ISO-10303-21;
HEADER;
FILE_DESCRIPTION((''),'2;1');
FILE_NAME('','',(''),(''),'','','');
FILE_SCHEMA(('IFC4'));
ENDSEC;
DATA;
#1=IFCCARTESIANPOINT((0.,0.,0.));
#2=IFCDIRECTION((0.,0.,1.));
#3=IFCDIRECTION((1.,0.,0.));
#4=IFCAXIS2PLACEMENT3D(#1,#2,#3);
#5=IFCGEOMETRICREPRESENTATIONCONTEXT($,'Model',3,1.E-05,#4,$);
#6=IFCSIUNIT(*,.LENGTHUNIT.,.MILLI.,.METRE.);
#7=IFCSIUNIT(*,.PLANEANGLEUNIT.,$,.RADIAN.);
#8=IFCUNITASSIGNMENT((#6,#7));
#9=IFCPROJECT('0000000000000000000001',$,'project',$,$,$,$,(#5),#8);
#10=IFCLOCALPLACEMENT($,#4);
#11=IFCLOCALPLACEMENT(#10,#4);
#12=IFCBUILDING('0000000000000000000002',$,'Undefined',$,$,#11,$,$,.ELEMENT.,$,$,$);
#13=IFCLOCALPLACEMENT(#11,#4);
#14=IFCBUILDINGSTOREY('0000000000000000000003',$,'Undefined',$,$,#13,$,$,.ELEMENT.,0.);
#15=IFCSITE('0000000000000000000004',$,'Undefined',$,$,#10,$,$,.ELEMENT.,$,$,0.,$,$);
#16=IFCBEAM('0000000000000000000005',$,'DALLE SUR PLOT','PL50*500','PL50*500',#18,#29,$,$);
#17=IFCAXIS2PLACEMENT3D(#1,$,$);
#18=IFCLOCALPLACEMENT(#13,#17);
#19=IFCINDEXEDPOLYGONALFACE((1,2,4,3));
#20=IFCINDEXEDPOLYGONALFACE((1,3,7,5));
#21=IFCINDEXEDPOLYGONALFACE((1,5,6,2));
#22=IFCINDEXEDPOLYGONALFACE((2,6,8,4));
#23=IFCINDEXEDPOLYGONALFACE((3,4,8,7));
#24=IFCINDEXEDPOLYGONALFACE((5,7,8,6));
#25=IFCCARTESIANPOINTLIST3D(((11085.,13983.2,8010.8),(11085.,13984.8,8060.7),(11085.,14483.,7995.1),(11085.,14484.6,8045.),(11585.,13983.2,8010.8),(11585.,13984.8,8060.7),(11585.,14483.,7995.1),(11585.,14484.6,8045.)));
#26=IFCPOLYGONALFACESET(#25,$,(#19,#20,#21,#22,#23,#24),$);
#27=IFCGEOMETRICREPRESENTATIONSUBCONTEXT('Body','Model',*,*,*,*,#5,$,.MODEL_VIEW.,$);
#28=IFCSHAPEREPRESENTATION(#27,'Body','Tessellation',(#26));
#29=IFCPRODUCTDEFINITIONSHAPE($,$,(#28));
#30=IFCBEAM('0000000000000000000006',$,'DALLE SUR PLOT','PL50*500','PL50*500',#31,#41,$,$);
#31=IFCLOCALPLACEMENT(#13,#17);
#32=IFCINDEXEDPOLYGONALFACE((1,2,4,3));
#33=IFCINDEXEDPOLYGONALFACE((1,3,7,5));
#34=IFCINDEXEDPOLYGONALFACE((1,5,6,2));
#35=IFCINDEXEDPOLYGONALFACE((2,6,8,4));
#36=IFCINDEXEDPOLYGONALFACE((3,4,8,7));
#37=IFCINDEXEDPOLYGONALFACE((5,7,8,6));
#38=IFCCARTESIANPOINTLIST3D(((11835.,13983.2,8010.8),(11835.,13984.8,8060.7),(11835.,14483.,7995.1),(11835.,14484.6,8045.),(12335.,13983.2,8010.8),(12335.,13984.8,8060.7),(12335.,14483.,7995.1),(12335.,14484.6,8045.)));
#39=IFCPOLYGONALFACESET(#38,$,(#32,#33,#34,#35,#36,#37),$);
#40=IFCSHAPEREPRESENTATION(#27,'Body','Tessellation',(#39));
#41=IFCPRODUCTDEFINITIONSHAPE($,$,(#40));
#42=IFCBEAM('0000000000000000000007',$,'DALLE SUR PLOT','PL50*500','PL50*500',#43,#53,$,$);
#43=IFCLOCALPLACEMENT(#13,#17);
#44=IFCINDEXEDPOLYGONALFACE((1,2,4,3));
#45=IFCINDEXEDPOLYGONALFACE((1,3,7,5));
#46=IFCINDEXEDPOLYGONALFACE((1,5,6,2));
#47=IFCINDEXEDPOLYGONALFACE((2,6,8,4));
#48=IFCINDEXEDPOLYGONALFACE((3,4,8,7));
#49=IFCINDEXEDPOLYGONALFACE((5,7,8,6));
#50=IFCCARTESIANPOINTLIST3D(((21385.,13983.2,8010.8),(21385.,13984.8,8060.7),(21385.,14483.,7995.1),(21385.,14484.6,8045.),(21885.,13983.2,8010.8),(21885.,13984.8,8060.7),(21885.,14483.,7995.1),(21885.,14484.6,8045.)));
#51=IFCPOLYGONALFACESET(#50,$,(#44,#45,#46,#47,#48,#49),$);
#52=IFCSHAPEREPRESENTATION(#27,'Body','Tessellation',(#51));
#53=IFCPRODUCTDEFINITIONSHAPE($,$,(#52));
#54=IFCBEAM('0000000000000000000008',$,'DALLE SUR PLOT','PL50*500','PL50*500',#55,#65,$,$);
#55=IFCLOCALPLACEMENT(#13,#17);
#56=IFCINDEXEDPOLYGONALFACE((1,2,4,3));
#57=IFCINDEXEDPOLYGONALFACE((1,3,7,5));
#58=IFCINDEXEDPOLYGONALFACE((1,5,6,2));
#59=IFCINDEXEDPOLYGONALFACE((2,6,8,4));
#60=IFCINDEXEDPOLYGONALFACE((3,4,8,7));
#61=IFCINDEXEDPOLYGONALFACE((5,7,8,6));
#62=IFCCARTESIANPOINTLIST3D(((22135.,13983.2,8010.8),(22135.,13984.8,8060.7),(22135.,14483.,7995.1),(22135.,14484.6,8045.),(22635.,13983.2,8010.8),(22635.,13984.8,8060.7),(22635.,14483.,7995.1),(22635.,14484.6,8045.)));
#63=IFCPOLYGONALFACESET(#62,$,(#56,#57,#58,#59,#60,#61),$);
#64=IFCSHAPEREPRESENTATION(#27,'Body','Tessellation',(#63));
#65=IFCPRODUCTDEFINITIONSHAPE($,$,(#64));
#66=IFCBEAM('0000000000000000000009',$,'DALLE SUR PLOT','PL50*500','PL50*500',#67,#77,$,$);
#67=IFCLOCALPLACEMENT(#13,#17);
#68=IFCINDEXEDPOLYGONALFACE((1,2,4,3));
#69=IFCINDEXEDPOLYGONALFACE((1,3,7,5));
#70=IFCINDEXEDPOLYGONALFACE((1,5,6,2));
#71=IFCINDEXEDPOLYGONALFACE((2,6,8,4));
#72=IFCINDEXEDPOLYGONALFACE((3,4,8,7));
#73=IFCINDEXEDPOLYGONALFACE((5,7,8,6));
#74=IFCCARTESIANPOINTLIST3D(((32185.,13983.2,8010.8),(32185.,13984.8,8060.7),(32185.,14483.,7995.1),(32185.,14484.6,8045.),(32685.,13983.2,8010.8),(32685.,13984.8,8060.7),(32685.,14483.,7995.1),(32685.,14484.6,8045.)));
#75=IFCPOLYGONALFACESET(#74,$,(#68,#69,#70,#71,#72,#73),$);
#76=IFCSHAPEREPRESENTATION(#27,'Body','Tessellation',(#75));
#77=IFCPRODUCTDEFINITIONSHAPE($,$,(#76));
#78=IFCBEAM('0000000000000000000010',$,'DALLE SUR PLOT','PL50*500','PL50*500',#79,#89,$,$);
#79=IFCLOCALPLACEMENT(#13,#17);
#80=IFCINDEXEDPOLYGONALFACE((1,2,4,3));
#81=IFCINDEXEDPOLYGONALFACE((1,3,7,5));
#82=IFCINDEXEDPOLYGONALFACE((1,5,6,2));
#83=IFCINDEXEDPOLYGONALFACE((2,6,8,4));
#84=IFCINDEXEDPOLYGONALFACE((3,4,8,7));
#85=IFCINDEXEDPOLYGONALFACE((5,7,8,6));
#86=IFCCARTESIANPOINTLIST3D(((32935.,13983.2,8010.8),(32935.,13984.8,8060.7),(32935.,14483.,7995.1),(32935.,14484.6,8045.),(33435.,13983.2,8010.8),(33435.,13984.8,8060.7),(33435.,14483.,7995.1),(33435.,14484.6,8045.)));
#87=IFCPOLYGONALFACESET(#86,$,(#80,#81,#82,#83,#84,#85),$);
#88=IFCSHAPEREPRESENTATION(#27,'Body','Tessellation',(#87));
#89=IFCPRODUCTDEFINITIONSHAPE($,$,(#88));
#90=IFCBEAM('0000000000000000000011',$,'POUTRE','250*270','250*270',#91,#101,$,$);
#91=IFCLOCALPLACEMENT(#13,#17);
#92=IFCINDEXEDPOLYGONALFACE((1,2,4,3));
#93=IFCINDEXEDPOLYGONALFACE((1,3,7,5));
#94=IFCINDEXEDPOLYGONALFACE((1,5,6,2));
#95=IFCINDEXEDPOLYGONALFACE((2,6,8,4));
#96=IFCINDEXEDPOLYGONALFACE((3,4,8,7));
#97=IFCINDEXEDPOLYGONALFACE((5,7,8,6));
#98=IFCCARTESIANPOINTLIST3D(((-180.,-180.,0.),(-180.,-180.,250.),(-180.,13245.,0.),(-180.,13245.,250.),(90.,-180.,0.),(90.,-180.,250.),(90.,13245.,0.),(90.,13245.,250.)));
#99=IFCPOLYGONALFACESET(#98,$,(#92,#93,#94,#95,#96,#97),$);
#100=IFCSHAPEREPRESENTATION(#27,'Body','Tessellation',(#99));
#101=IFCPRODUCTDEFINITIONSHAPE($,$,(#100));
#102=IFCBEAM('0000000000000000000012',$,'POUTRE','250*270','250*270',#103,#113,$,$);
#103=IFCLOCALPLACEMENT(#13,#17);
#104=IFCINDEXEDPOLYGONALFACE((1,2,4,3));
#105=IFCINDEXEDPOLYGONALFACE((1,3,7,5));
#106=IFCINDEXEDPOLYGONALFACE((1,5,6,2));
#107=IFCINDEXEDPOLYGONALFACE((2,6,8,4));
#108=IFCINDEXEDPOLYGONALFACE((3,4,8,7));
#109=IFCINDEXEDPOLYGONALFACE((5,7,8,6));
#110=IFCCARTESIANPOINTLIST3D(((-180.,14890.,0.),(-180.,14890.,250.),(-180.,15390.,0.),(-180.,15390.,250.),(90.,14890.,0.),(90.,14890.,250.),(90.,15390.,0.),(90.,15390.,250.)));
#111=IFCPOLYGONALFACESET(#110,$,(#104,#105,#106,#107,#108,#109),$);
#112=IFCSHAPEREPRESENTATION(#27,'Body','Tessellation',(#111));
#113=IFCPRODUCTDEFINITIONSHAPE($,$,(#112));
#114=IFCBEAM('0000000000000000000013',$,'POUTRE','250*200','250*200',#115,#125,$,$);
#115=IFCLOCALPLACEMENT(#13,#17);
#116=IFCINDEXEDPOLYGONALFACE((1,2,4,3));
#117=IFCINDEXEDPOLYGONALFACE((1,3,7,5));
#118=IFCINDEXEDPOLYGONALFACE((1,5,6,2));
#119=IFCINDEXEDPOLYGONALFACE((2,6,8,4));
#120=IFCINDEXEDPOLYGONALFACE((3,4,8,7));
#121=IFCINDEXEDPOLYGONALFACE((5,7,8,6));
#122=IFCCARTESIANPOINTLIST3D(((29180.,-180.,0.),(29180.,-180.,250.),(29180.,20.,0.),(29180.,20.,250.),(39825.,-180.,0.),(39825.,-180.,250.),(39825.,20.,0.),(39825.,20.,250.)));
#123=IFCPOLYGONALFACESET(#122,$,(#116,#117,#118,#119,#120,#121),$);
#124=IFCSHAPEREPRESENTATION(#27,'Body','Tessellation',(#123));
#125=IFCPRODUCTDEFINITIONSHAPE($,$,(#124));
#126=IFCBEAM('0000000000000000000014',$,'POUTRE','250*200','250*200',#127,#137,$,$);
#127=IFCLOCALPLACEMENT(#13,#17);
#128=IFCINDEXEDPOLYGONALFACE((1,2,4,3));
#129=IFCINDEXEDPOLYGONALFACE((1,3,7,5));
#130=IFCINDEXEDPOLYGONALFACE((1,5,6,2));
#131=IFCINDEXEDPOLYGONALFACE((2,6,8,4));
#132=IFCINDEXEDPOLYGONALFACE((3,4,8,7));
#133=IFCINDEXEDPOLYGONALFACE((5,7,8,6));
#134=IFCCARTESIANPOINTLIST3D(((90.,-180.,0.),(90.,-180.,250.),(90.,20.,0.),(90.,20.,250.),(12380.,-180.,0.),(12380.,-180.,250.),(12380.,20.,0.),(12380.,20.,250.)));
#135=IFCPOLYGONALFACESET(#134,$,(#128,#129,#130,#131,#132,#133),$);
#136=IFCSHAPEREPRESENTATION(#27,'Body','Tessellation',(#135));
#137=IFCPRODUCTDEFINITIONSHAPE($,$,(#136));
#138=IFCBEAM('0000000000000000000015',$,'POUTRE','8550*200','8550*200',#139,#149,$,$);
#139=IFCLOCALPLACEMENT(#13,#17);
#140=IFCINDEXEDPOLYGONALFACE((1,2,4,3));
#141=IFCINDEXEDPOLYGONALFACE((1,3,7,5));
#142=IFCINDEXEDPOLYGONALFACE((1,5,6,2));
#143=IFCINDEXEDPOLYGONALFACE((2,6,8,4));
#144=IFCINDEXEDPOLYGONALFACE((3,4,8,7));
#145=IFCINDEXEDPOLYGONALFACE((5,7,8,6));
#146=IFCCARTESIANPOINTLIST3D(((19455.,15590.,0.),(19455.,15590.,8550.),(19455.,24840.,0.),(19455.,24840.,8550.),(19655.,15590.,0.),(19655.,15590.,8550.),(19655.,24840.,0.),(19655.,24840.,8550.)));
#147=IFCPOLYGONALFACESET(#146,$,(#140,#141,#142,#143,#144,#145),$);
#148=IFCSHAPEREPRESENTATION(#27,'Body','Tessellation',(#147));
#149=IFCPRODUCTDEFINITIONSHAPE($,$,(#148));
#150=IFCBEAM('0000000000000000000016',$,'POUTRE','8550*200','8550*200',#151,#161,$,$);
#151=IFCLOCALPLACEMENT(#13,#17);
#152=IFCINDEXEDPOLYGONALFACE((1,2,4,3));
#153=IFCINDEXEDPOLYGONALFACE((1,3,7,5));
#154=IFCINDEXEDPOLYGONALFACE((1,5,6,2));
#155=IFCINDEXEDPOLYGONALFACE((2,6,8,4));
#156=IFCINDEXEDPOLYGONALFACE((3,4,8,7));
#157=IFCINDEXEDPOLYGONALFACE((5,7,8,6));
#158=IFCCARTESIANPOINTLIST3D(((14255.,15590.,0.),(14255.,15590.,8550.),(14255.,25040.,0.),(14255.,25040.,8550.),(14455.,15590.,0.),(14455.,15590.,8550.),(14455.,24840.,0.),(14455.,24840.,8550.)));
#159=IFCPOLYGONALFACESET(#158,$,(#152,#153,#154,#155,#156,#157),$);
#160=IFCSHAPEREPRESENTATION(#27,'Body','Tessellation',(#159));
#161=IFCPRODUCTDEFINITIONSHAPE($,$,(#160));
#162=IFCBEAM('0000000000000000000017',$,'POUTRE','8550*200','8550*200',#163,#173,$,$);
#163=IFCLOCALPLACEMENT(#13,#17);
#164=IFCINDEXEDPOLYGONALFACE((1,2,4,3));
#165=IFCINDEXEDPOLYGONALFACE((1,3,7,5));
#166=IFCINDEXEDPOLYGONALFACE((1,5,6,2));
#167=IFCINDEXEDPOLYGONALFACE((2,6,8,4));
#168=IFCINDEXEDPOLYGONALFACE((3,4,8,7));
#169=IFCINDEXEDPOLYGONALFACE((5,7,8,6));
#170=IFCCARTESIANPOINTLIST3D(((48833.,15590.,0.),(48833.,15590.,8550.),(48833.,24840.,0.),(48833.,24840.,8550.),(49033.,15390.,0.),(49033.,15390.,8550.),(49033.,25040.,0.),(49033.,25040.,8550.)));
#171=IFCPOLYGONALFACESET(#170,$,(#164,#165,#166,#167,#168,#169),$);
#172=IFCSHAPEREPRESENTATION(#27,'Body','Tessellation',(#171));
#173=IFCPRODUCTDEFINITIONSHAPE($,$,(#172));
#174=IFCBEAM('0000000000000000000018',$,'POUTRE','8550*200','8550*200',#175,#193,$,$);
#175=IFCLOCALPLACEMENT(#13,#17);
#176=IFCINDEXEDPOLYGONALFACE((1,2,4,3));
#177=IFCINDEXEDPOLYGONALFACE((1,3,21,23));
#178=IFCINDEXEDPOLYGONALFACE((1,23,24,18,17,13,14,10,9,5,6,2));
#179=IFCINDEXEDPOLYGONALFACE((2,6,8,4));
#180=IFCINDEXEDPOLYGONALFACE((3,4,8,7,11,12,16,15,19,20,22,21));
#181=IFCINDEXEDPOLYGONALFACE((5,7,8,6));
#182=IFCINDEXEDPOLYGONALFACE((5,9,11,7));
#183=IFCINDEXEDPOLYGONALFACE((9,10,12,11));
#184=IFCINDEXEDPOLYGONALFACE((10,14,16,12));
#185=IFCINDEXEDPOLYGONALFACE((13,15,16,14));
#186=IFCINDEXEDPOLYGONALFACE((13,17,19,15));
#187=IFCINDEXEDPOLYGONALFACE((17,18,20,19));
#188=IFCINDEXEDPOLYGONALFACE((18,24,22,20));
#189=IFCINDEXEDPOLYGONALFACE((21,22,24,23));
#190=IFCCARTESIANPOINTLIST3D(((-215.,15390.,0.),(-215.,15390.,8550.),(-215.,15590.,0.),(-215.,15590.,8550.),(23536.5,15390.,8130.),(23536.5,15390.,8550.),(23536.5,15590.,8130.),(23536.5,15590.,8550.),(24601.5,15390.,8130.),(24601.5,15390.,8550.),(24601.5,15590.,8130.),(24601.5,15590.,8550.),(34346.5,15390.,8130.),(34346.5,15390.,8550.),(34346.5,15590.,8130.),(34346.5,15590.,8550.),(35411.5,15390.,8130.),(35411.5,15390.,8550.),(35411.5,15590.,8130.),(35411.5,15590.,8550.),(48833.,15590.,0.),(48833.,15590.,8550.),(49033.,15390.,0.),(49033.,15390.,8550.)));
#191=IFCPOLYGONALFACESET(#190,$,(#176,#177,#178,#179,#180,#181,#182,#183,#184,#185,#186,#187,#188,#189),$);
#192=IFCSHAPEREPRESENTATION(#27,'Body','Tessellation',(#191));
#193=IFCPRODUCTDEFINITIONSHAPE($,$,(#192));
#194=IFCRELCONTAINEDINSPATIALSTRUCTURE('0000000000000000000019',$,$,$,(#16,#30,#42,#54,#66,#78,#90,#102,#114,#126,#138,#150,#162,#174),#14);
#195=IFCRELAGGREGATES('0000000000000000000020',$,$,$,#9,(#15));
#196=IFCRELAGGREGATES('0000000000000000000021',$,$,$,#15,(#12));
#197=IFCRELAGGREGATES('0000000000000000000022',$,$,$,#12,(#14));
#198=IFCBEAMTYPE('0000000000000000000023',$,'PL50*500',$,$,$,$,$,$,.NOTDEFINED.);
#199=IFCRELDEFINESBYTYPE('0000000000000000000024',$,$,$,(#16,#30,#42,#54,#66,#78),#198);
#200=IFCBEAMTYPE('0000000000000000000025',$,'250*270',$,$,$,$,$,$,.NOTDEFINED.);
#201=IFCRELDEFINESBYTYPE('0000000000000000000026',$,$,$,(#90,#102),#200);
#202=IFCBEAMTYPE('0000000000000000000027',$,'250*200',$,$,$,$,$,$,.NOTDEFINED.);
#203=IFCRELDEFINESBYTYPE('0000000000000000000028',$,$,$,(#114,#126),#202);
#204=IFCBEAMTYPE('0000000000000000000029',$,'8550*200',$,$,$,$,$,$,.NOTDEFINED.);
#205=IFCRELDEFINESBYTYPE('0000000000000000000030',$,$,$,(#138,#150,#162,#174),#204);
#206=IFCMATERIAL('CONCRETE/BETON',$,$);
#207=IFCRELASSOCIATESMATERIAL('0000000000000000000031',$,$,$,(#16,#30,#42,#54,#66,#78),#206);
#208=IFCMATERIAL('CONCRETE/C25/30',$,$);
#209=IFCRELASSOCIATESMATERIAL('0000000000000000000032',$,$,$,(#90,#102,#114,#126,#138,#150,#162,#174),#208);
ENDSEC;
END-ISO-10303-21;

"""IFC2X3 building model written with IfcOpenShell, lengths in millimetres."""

from ifc_helpers import new_model, si_unit, frame, origin_with_axes, origin_2d_with_axis, place, context, subcontext, project, spatial, polyline, rectangle, outline, extrude, boolean, clip, halfspace, material, type_object, element, save


model = new_model("IFC2X3")

# Units and contexts
model_context = context("Model", 3, precision=1e-05, world=origin_with_axes())
body_context = subcontext(model_context, "Body", "Model", "MODEL_VIEW")
ifc_project = project(units=[si_unit("LENGTHUNIT", "METRE", prefix="MILLI"), si_unit("PLANEANGLEUNIT", "RADIAN")], contexts=[model_context])

# Site, building, storey
site_placement = place(None, origin_with_axes())
site = spatial("IfcSite", under=ifc_project, at=site_placement, Name="Undefined", CompositionType="ELEMENT", RefElevation=0.0)
building_placement = place(site_placement, origin_with_axes())
building = spatial("IfcBuilding", under=site, at=building_placement, Name="Undefined", CompositionType="ELEMENT")
storey_placement = place(building_placement, origin_with_axes())
storey = spatial("IfcBuildingStorey", under=building, at=storey_placement, Name="Undefined", CompositionType="ELEMENT", Elevation=0.0)

# Beams
ifc_material_1 = material(Name="CONCRETE/BETON")
beam_type_1 = type_object("IfcBeamType", Name="PL50*500", PredefinedType="NOTDEFINED")
for number, where, z_axis, x_axis, name in (
    (1, (11335.0, 14483.8, 8020.0), (-1.0, 0.0, 0.0), (0.0, -0.999507, 0.031411), "DALLE SUR PLOT"),
    (2, (12085.0, 14483.8, 8020.0), (-1.0, 0.0, 0.0), (0.0, -0.999507, 0.031411), "DALLE SUR PLOT"),
    (3, (21635.0, 14483.8, 8020.0), (-1.0, 0.0, 0.0), (0.0, -0.999507, 0.031411), "DALLE SUR PLOT"),
    (4, (22385.0, 14483.8, 8020.0), (-1.0, 0.0, 0.0), (0.0, -0.999507, 0.031411), "DALLE SUR PLOT"),
    (5, (32435.0, 14483.8, 8020.0), (-1.0, 0.0, 0.0), (0.0, -0.999507, 0.031411), "DALLE SUR PLOT"),
    (6, (33185.0, 14483.8, 8020.0), (-1.0, 0.0, 0.0), (0.0, -0.999507, 0.031411), "DALLE SUR PLOT"),
):
    element("IfcBeam", number, at=place(storey_placement, frame(where, z_axis=z_axis, x_axis=x_axis)), inside=storey, type_object=beam_type_1, material=ifc_material_1, Name=name, Description="PL50*500", ObjectType="PL50*500", context=body_context, shape_type="SweptSolid", body=[
        extrude(rectangle(XDim=50.0, YDim=500.0, at=origin_2d_with_axis()), frame((500.0, 0.0, 0.0), z_axis=(-1.0, 0.0, 0.0), x_axis=(0.0, -1.0, 0.0)), (0.0, 0.0, 1.0), 500.0),
    ])
ifc_material_2 = material(Name="CONCRETE/C25/30")
beam_type_2 = type_object("IfcBeamType", Name="250*270", PredefinedType="NOTDEFINED")
beam_1_placement = place(storey_placement, frame((-45.0, 13245.0, 125.0), z_axis=(0.0, 0.0, 1.0), x_axis=(0.0, -1.0, 0.0)))
element("IfcBeam", 7, at=beam_1_placement, inside=storey, type_object=beam_type_2, material=ifc_material_2, Name="POUTRE", Description="250*270", ObjectType="250*270", context=body_context, shape_type="SweptSolid", body=[
    extrude(rectangle(XDim=270.0, YDim=250.0, at=origin_2d_with_axis()), frame((13425.0, 0.0, 0.0), z_axis=(-1.0, 0.0, 0.0), x_axis=(0.0, -1.0, 0.0)), (0.0, 0.0, 1.0), 13425.0),
])
beam_2_placement = place(storey_placement, frame((-45.0, 15390.0, 125.0), z_axis=(0.0, 0.0, 1.0), x_axis=(0.0, -1.0, 0.0)))
element("IfcBeam", 8, at=beam_2_placement, inside=storey, type_object=beam_type_2, material=ifc_material_2, Name="POUTRE", Description="250*270", ObjectType="250*270", context=body_context, shape_type="SweptSolid", body=[
    extrude(rectangle(XDim=270.0, YDim=250.0, at=origin_2d_with_axis()), frame((500.0, 0.0, 0.0), z_axis=(-1.0, 0.0, 0.0), x_axis=(0.0, -1.0, 0.0)), (0.0, 0.0, 1.0), 500.0),
])
beam_type_3 = type_object("IfcBeamType", Name="250*200", PredefinedType="NOTDEFINED")
beam_3_placement = place(storey_placement, frame((29180.0, -80.0, 125.0), z_axis=(0.0, 0.0, 1.0), x_axis=(1.0, 0.0, 0.0)))
element("IfcBeam", 9, at=beam_3_placement, inside=storey, type_object=beam_type_3, material=ifc_material_2, Name="POUTRE", Description="250*200", ObjectType="250*200", context=body_context, shape_type="SweptSolid", body=[
    extrude(rectangle(XDim=200.0, YDim=250.0, at=origin_2d_with_axis()), frame((10645.0, 0.0, 0.0), z_axis=(-1.0, 0.0, 0.0), x_axis=(0.0, -1.0, 0.0)), (0.0, 0.0, 1.0), 10645.0),
])
beam_4_placement = place(storey_placement, frame((90.0, -80.0, 125.0), z_axis=(0.0, 0.0, 1.0), x_axis=(1.0, 0.0, 0.0)))
element("IfcBeam", 10, at=beam_4_placement, inside=storey, type_object=beam_type_3, material=ifc_material_2, Name="POUTRE", Description="250*200", ObjectType="250*200", context=body_context, shape_type="SweptSolid", body=[
    extrude(rectangle(XDim=200.0, YDim=250.0, at=origin_2d_with_axis()), frame((12290.0, 0.0, 0.0), z_axis=(-1.0, 0.0, 0.0), x_axis=(0.0, -1.0, 0.0)), (0.0, 0.0, 1.0), 12290.0),
])
beam_type_4 = type_object("IfcBeamType", Name="8550*200", PredefinedType="NOTDEFINED")
beam_5_placement = place(storey_placement, frame((19555.0, 15590.0, 4275.0), z_axis=(0.0, 0.0, 1.0), x_axis=(0.0, 1.0, 0.0)))
element("IfcBeam", 11, at=beam_5_placement, inside=storey, type_object=beam_type_4, material=ifc_material_2, Name="POUTRE", Description="8550*200", ObjectType="8550*200", context=body_context, shape_type="SweptSolid", body=[
    extrude(rectangle(XDim=200.0, YDim=8550.0, at=origin_2d_with_axis()), frame((9250.0, 0.0, 0.0), z_axis=(-1.0, 0.0, 0.0), x_axis=(0.0, -1.0, 0.0)), (0.0, 0.0, 1.0), 9250.0),
])
beam_6_placement = place(storey_placement, frame((14355.0, 15590.0, 4275.0), z_axis=(0.0, 0.0, 1.0), x_axis=(0.0, 1.0, 0.0)))
element("IfcBeam", 12, at=beam_6_placement, inside=storey, type_object=beam_type_4, material=ifc_material_2, Name="POUTRE", Description="8550*200", ObjectType="8550*200", context=body_context, shape_type="Clipping", body=[
    clip(extrude(rectangle(XDim=200.0, YDim=8550.0, at=origin_2d_with_axis()), frame((9451.0, 0.0, 0.0), z_axis=(-1.0, 0.0, 0.0), x_axis=(0.0, -1.0, 0.0)), (0.0, 0.0, 1.0), 9451.0), halfspace(frame((9450.0, 100.0, -4275.0), z_axis=(-0.707107, 0.707107, 0.0), x_axis=(0.0, 0.0, 1.0)), True)),
])
beam_7_placement = place(storey_placement, frame((48933.0, 15390.0, 4275.0), z_axis=(0.0, 0.0, 1.0), x_axis=(0.0, 1.0, 0.0)))
element("IfcBeam", 13, at=beam_7_placement, inside=storey, type_object=beam_type_4, material=ifc_material_2, Name="POUTRE", Description="8550*200", ObjectType="8550*200", context=body_context, shape_type="Clipping", body=[
    clip(clip(extrude(rectangle(XDim=200.0, YDim=8550.0, at=origin_2d_with_axis()), frame((9752.0, 0.0, 0.0), z_axis=(-1.0, 0.0, 0.0), x_axis=(0.0, -1.0, 0.0)), (0.0, 0.0, 1.0), 9854.0), halfspace(frame((9650.0, -100.0, -4275.0), z_axis=(0.707107, 0.707107, 0.0), x_axis=(0.0, 0.0, 1.0)), False)), halfspace(frame((200.0, 100.0, -4275.0), z_axis=(-0.707107, 0.707107, 0.0), x_axis=(0.0, 0.0, 1.0)), False)),
])
beam_8_placement = place(storey_placement, frame((49033.0, 15490.0, 4275.0), z_axis=(0.0, 0.0, 1.0), x_axis=(-1.0, 0.0, 0.0)))
element("IfcBeam", 14, at=beam_8_placement, inside=storey, type_object=beam_type_4, material=ifc_material_2, Name="POUTRE", Description="8550*200", ObjectType="8550*200", context=body_context, shape_type="CSG", body=[
    boolean("DIFFERENCE", boolean("DIFFERENCE", boolean("DIFFERENCE", extrude(rectangle(XDim=200.0, YDim=8550.0, at=origin_2d_with_axis()), frame((49248.0, 0.0, 0.0), z_axis=(-1.0, 0.0, 0.0), x_axis=(0.0, -1.0, 0.0)), (0.0, 0.0, 1.0), 49249.0), extrude(outline(polyline([(0.0, 0.0), (420.0, 0.0), (420.0, 1065.0), (0.0, 1065.0), (0.0, 0.0)])), frame((25496.5, -102.5, 4275.0), z_axis=(0.0, 1.0, 0.0), x_axis=(0.0, 0.0, -1.0)), (0.0, 0.0, 1.0), 205.0)), extrude(outline(polyline([(0.0, 0.0), (420.0, 0.0), (420.0, 1065.0), (0.0, 1065.0), (0.0, 0.0)])), frame((14686.5, -102.5, 4275.0), z_axis=(0.0, 1.0, 0.0), x_axis=(0.0, 0.0, -1.0)), (0.0, 0.0, 1.0), 205.0)), halfspace(frame((200.0, -100.0, -4275.0), z_axis=(0.707107, 0.707107, 0.0), x_axis=(0.0, 0.0, 1.0)), True)),
])

save(model, "model.ifc")
